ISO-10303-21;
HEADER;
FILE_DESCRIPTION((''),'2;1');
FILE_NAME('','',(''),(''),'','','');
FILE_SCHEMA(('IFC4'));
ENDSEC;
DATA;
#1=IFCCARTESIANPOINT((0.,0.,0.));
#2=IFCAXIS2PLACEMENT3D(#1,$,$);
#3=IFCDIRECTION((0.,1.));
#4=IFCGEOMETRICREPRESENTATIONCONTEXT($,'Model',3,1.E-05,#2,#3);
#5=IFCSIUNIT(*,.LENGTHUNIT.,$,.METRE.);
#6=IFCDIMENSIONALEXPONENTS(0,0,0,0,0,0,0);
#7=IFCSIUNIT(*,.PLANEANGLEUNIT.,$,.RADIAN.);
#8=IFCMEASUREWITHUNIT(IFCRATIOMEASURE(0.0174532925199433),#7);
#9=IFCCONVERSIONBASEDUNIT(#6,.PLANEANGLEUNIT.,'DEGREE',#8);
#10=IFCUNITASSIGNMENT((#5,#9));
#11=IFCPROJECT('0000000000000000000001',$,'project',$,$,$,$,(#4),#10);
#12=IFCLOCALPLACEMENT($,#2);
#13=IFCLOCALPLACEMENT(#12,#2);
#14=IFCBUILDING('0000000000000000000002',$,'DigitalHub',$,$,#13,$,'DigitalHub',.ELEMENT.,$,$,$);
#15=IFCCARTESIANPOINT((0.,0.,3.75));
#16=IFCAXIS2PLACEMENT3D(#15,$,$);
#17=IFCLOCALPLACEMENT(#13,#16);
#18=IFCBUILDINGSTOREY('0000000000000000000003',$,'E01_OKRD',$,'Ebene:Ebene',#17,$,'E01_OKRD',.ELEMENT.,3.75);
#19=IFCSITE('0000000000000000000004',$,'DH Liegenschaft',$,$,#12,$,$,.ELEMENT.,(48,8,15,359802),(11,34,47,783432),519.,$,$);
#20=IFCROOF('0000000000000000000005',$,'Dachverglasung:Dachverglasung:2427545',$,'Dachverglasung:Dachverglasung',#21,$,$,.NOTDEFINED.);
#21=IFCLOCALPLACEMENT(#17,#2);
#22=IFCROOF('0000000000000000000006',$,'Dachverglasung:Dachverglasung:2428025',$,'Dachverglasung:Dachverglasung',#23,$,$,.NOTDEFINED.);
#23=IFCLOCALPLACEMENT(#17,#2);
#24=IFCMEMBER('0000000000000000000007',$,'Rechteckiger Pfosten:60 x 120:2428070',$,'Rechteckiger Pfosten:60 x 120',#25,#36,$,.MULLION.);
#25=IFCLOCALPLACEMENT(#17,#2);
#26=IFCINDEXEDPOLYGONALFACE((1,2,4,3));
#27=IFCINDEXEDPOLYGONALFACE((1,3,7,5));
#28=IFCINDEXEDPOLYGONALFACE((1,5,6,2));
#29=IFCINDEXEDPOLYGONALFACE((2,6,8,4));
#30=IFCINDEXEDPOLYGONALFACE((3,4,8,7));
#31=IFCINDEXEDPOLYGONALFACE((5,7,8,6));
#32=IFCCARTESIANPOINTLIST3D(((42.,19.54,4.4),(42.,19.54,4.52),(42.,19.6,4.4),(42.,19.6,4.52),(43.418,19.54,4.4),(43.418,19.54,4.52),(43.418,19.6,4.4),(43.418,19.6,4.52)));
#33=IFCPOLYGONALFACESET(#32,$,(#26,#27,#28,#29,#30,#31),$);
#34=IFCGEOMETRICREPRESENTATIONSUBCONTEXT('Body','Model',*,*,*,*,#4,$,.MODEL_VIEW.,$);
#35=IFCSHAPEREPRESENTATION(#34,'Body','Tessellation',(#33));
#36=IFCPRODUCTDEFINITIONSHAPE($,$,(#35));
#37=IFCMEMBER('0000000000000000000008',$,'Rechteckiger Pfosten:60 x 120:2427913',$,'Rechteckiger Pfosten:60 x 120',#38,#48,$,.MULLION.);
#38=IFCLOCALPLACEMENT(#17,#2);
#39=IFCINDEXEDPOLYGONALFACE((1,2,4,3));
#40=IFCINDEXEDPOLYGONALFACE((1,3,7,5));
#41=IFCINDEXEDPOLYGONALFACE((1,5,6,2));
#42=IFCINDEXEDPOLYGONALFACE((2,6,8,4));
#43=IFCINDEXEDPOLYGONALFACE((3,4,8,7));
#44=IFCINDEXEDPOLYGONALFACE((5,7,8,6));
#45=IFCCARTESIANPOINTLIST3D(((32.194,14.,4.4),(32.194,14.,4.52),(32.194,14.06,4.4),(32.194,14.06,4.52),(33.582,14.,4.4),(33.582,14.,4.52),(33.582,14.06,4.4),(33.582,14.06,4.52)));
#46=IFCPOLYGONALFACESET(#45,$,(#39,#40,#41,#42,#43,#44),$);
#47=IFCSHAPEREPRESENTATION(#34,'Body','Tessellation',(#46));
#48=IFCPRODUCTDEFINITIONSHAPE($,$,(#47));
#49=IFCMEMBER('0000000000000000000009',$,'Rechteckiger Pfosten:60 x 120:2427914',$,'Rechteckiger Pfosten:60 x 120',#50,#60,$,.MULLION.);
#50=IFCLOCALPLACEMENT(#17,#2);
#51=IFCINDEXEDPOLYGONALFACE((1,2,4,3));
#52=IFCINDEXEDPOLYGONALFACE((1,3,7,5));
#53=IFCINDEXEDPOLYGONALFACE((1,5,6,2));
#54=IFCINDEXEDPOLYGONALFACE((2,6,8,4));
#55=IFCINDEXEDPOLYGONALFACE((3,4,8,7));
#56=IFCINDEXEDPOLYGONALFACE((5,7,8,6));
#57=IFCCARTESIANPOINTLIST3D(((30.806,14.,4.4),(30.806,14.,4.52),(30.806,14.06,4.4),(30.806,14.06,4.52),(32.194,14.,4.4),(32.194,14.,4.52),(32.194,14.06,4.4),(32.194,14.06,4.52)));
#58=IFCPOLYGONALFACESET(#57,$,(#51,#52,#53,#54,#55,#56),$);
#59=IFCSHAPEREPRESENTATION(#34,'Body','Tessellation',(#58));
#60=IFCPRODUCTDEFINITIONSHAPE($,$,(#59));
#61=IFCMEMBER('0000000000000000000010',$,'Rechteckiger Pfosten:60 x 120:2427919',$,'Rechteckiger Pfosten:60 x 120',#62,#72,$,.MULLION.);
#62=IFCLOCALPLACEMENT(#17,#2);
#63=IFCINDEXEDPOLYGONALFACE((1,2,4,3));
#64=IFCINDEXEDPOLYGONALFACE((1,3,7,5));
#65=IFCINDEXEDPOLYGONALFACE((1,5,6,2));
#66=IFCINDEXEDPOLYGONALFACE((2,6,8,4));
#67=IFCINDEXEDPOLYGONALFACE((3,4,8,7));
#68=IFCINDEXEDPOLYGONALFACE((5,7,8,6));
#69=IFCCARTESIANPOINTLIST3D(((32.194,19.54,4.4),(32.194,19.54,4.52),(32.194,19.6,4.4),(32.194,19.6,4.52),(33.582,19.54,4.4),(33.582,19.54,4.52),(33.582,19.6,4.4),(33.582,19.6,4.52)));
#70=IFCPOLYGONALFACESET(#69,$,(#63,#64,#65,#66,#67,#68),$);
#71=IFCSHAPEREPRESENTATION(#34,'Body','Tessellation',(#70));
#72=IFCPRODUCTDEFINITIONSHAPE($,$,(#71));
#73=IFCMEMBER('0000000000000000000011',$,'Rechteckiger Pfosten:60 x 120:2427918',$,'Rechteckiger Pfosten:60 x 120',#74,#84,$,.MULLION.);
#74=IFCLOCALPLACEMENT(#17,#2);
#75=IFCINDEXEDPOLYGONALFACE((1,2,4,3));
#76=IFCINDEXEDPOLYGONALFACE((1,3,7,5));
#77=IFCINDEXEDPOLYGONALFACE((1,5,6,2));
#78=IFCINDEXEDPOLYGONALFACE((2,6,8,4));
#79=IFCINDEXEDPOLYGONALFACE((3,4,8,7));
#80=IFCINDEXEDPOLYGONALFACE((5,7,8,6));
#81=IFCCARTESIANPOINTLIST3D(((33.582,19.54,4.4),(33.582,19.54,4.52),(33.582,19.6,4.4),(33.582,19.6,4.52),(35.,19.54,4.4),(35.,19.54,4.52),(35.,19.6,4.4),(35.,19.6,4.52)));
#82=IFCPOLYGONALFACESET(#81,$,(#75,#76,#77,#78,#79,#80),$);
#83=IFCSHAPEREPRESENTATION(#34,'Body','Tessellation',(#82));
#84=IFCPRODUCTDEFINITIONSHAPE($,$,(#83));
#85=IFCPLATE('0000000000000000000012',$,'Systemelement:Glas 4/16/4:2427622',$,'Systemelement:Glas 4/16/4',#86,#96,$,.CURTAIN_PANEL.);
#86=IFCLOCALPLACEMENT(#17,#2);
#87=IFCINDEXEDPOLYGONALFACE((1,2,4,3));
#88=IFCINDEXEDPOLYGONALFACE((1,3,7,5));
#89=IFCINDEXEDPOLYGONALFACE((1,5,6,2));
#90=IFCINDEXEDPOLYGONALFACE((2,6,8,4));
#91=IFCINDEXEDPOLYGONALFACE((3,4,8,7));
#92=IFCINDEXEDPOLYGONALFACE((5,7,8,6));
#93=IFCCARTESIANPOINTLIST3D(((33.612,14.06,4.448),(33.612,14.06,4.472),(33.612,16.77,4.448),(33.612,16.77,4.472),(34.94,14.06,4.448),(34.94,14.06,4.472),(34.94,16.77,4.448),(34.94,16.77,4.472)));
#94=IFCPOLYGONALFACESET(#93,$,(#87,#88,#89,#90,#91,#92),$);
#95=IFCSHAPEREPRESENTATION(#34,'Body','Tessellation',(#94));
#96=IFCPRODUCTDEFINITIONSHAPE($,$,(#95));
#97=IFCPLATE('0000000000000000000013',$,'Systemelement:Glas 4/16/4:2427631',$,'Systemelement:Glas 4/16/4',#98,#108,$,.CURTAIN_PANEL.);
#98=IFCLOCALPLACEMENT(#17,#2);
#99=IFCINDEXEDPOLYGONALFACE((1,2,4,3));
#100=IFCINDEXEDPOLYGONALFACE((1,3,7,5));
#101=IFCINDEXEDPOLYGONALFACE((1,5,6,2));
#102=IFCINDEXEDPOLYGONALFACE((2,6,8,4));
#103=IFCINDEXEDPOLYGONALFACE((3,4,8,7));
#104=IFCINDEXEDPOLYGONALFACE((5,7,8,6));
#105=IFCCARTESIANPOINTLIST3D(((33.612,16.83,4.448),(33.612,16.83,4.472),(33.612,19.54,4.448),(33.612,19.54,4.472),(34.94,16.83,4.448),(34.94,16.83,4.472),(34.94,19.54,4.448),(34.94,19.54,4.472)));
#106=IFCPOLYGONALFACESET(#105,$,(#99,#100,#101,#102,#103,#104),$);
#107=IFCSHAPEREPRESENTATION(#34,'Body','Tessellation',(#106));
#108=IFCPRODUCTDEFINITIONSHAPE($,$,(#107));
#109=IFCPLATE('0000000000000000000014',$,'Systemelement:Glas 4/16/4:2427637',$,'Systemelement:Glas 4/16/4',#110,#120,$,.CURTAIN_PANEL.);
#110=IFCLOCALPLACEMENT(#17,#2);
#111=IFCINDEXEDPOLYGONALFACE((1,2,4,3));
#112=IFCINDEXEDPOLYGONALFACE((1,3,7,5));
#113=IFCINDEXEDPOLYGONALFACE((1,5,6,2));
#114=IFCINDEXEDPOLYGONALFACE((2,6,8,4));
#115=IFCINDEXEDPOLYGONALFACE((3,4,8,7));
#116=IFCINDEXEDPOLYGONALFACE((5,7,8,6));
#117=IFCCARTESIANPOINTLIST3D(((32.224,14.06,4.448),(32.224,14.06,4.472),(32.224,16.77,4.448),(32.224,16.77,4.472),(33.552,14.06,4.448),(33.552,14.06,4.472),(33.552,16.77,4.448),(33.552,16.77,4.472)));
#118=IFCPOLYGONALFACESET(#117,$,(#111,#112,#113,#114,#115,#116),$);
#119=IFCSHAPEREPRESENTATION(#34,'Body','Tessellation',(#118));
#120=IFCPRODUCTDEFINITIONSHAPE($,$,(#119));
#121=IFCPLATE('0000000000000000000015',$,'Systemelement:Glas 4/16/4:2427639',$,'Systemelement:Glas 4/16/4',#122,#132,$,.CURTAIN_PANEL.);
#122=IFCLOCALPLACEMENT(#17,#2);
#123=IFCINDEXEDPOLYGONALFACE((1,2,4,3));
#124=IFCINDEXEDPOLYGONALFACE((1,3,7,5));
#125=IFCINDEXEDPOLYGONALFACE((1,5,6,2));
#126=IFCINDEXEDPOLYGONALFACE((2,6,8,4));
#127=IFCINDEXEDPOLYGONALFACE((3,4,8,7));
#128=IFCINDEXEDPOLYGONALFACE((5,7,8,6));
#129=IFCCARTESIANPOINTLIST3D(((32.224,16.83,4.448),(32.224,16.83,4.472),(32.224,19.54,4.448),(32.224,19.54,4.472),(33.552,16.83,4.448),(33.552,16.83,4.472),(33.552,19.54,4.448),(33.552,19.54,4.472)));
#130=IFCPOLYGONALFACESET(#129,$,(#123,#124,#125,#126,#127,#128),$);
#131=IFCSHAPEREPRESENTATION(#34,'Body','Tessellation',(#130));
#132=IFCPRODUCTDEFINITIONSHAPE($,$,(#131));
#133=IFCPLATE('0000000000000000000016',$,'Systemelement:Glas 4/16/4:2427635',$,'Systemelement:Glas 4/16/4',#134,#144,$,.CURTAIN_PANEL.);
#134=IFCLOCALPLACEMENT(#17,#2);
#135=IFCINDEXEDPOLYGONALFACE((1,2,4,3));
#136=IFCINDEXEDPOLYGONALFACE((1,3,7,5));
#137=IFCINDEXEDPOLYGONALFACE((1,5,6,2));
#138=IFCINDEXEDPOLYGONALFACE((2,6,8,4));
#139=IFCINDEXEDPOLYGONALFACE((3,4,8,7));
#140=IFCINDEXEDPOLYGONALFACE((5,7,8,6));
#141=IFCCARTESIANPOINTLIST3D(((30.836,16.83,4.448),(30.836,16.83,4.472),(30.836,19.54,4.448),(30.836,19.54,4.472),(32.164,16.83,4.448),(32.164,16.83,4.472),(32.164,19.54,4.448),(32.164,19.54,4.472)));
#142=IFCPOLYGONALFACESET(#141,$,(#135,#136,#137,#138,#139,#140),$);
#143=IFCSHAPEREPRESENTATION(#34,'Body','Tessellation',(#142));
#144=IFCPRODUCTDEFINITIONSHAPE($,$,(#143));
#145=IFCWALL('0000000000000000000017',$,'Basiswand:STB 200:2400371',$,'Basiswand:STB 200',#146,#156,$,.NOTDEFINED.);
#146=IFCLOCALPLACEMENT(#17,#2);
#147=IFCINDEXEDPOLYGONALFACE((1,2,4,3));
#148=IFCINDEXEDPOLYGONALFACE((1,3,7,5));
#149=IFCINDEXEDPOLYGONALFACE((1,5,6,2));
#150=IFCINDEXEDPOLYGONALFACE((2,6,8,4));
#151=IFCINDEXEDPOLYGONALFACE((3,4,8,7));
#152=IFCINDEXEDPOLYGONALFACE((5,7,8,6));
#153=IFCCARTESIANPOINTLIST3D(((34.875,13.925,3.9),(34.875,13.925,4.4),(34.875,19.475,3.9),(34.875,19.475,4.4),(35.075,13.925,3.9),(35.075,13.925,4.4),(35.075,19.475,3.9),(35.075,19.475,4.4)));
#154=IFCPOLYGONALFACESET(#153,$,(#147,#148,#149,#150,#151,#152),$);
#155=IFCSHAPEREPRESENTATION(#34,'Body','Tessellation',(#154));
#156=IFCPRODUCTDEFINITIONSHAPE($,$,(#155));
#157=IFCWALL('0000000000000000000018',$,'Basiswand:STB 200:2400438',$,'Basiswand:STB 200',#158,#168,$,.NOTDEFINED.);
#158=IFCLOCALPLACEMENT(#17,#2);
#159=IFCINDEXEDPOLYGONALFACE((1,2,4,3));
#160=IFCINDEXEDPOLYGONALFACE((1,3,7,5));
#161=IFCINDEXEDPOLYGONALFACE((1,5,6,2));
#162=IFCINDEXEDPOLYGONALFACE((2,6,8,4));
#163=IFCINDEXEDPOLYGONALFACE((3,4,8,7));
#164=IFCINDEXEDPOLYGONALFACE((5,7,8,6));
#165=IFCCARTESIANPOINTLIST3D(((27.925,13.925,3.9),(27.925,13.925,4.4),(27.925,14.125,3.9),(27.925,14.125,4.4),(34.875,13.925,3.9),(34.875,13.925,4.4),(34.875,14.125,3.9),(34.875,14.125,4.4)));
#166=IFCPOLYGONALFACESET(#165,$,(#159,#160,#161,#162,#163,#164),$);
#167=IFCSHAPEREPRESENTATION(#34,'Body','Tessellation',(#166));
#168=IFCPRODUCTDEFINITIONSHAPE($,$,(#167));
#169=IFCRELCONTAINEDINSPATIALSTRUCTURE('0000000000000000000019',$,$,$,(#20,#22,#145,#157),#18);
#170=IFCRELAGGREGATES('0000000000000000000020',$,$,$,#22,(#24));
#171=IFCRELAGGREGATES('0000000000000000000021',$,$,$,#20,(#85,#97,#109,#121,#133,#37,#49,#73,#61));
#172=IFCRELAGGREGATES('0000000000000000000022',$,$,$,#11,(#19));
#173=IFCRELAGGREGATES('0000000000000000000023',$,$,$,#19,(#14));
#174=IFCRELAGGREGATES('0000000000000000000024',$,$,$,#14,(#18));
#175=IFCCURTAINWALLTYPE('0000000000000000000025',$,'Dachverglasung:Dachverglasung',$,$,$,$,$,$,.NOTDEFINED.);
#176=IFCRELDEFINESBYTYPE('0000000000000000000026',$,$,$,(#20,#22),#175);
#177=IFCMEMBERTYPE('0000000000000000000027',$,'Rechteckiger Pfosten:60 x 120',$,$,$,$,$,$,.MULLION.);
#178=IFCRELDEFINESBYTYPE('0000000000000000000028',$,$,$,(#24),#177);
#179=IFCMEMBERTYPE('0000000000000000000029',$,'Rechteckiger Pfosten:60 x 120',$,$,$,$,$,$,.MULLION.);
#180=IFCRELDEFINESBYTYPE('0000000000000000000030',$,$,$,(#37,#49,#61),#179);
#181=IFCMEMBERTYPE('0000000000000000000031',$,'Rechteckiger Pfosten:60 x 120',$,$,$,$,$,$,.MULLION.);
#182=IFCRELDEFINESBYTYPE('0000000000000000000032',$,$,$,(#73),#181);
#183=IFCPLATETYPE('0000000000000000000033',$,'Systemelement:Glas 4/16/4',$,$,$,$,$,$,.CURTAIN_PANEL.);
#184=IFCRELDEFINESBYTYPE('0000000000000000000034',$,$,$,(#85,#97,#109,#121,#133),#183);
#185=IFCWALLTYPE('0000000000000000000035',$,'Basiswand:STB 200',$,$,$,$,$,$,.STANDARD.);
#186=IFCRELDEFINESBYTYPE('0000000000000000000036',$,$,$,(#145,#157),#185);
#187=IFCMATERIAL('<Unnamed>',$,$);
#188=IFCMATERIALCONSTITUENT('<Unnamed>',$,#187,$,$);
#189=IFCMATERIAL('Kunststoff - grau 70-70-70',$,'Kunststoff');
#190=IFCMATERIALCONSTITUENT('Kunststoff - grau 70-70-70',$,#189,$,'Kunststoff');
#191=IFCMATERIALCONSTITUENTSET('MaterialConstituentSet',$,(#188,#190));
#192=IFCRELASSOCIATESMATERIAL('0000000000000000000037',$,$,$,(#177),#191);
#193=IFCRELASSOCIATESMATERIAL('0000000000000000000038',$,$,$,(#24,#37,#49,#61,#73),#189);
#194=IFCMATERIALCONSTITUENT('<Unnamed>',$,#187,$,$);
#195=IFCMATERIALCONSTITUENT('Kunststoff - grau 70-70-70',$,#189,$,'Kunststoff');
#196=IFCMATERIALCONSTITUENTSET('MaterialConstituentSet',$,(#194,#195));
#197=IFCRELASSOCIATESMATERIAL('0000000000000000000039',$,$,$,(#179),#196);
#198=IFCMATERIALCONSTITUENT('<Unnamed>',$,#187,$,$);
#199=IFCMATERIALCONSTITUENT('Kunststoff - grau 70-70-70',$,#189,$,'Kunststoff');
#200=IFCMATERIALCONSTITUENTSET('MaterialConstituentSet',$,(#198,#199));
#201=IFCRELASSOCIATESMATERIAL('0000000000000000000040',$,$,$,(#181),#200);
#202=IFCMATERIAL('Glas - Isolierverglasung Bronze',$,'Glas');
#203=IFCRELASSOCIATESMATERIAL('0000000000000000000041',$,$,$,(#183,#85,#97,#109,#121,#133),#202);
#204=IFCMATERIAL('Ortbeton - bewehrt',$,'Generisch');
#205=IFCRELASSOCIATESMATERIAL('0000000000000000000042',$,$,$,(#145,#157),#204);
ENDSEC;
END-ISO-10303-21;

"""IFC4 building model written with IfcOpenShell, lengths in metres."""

from ifc_helpers import new_model, entity, si_unit, converted_unit, direction, frame, origin, place, context, subcontext, project, spatial, indexed_curve, outline, extrude, source, transform, mapped, material, constituent, constituent_set, type_object, type_shapes, element, aggregate, save


model = new_model("IFC4")

# Units and contexts
model_context = context("Model", 3, precision=1e-05, world=origin(), true_north=direction((0.0, 1.0)))
body_context = subcontext(model_context, "Body", "Model", "MODEL_VIEW")
ifc_project = project(units=[si_unit("LENGTHUNIT", "METRE"), converted_unit("PLANEANGLEUNIT", "DEGREE", entity("IfcRatioMeasure", 0.0174532925199433), si_unit("PLANEANGLEUNIT", "RADIAN"), dimensions=[0, 0, 0, 0, 0, 0, 0])], contexts=[model_context])

# Site, building, storey
site_placement = place(None, frame((0.0, 0.0, 0.0)))
site = spatial("IfcSite", under=ifc_project, at=site_placement, Name="DH Liegenschaft", CompositionType="ELEMENT", RefLatitude=(48, 8, 15, 359802), RefLongitude=(11, 34, 47, 783432), RefElevation=519.0)
building_placement = place(site_placement, origin())
building = spatial("IfcBuilding", under=site, at=building_placement, Name="DigitalHub", LongName="DigitalHub", CompositionType="ELEMENT")
storey_placement = place(building_placement, frame((0.0, 0.0, 3.75)))
storey = spatial("IfcBuildingStorey", under=building, at=storey_placement, Name="E01_OKRD", ObjectType="Ebene:Ebene", LongName="E01_OKRD", CompositionType="ELEMENT", Elevation=3.75)

# Roof
curtain_wall_type = type_object("IfcCurtainWallType", Name="Dachverglasung:Dachverglasung", PredefinedType="NOTDEFINED")
roof_1_placement = place(storey_placement, frame((0.0, 0.0, -3.75)))
roof_1 = element("IfcRoof", 1, at=roof_1_placement, inside=storey, type_object=curtain_wall_type, Name="Dachverglasung:Dachverglasung:2427545", ObjectType="Dachverglasung:Dachverglasung", PredefinedType="NOTDEFINED")
ifc_material_1 = material(Name="Kunststoff - grau 70-70-70", Category="Kunststoff")
ifc_material_2 = material(Name="<Unnamed>")

# Roof
roof_2_placement = place(storey_placement, frame((0.0, 0.0, -3.75)))
roof_2 = element("IfcRoof", 2, at=roof_2_placement, inside=storey, type_object=curtain_wall_type, Name="Dachverglasung:Dachverglasung:2428025", ObjectType="Dachverglasung:Dachverglasung", PredefinedType="NOTDEFINED")

# Members
ifc_constituent_1 = constituent(ifc_material_2, Name="<Unnamed>")
ifc_constituent_2 = constituent(ifc_material_1, Name="Kunststoff - grau 70-70-70", Category="Kunststoff")
ifc_constituent_set_1 = constituent_set(constituents=[ifc_constituent_1, ifc_constituent_2], Name="MaterialConstituentSet")
member_type_1 = type_object("IfcMemberType", Name="Rechteckiger Pfosten:60 x 120", PredefinedType="MULLION", material=ifc_constituent_set_1)
shared_shape_1 = source(origin(), body_context, "Body", "SweptSolid", [
    extrude(outline(indexed_curve([(-0.06, -0.03), (0.06, -0.03), (0.06, 0.03), (-0.06, 0.03), (-0.06, -0.03)], self_intersect=False)), frame((-0.03, 0.0, -1.418), z_axis=(0.0, 0.0, 1.0), x_axis=(0.0, -1.0, 0.0)), (0.0, 0.0, 1.0), 1.418),
])
type_shapes(member_type_1, [shared_shape_1])
member_1_placement = place(storey_placement, frame((42.0, 19.6, 4.46), z_axis=(-1.0, 0.0, 0.0), x_axis=(0.0, 1.0, 0.0)))
member_1 = element("IfcMember", 3, at=member_1_placement, type_object=member_type_1, material=ifc_material_1, Name="Rechteckiger Pfosten:60 x 120:2428070", ObjectType="Rechteckiger Pfosten:60 x 120", PredefinedType="MULLION", context=body_context, shape_type="MappedRepresentation", body=[
    mapped(shared_shape_1, transform((0.0, 0.0, 0.0), scale=1.0)),
])
aggregate(roof_2, [member_1])
ifc_constituent_3 = constituent(ifc_material_2, Name="<Unnamed>")
ifc_constituent_4 = constituent(ifc_material_1, Name="Kunststoff - grau 70-70-70", Category="Kunststoff")
ifc_constituent_set_2 = constituent_set(constituents=[ifc_constituent_3, ifc_constituent_4], Name="MaterialConstituentSet")
member_type_2 = type_object("IfcMemberType", Name="Rechteckiger Pfosten:60 x 120", PredefinedType="MULLION", material=ifc_constituent_set_2)
shared_shape_2 = source(origin(), body_context, "Body", "SweptSolid", [
    extrude(outline(indexed_curve([(-0.06, -0.03), (0.06, -0.03), (0.06, 0.03), (-0.06, 0.03), (-0.06, -0.03)], self_intersect=False)), frame((-0.03, 0.0, -1.388), z_axis=(0.0, 0.0, 1.0), x_axis=(0.0, -1.0, 0.0)), (0.0, 0.0, 1.0), 1.388),
])
type_shapes(member_type_2, [shared_shape_2])
member_2_placement = place(storey_placement, frame((33.582, 14.0, 4.46), z_axis=(1.0, 0.0, 0.0), x_axis=(0.0, -1.0, 0.0)))
member_2 = element("IfcMember", 4, at=member_2_placement, type_object=member_type_2, material=ifc_material_1, Name="Rechteckiger Pfosten:60 x 120:2427913", ObjectType="Rechteckiger Pfosten:60 x 120", PredefinedType="MULLION", context=body_context, shape_type="MappedRepresentation", body=[
    mapped(shared_shape_2, transform((0.0, 0.0, 0.0), scale=1.0)),
])
member_3_placement = place(storey_placement, frame((32.194, 14.0, 4.46), z_axis=(1.0, 0.0, 0.0), x_axis=(0.0, -1.0, 0.0)))
member_3 = element("IfcMember", 5, at=member_3_placement, type_object=member_type_2, material=ifc_material_1, Name="Rechteckiger Pfosten:60 x 120:2427914", ObjectType="Rechteckiger Pfosten:60 x 120", PredefinedType="MULLION", context=body_context, shape_type="MappedRepresentation", body=[
    mapped(shared_shape_2, transform((0.0, 0.0, 0.0), scale=1.0)),
])
member_4_placement = place(storey_placement, frame((32.194, 19.6, 4.46), z_axis=(-1.0, 0.0, 0.0), x_axis=(0.0, 1.0, 0.0)))
member_4 = element("IfcMember", 6, at=member_4_placement, type_object=member_type_2, material=ifc_material_1, Name="Rechteckiger Pfosten:60 x 120:2427919", ObjectType="Rechteckiger Pfosten:60 x 120", PredefinedType="MULLION", context=body_context, shape_type="MappedRepresentation", body=[
    mapped(shared_shape_2, transform((0.0, 0.0, 0.0), scale=1.0)),
])
ifc_constituent_5 = constituent(ifc_material_2, Name="<Unnamed>")
ifc_constituent_6 = constituent(ifc_material_1, Name="Kunststoff - grau 70-70-70", Category="Kunststoff")
ifc_constituent_set_3 = constituent_set(constituents=[ifc_constituent_5, ifc_constituent_6], Name="MaterialConstituentSet")
member_type_3 = type_object("IfcMemberType", Name="Rechteckiger Pfosten:60 x 120", PredefinedType="MULLION", material=ifc_constituent_set_3)
shared_shape_3 = source(origin(), body_context, "Body", "SweptSolid", [
    extrude(outline(indexed_curve([(-0.06, -0.03), (0.06, -0.03), (0.06, 0.03), (-0.06, 0.03), (-0.06, -0.03)], self_intersect=False)), frame((-0.03, 0.0, -1.418), z_axis=(0.0, 0.0, 1.0), x_axis=(0.0, -1.0, 0.0)), (0.0, 0.0, 1.0), 1.418),
])
type_shapes(member_type_3, [shared_shape_3])
member_5_placement = place(storey_placement, frame((33.582, 19.6, 4.46), z_axis=(-1.0, 0.0, 0.0), x_axis=(0.0, 1.0, 0.0)))
member_5 = element("IfcMember", 7, at=member_5_placement, type_object=member_type_3, material=ifc_material_1, Name="Rechteckiger Pfosten:60 x 120:2427918", ObjectType="Rechteckiger Pfosten:60 x 120", PredefinedType="MULLION", context=body_context, shape_type="MappedRepresentation", body=[
    mapped(shared_shape_3, transform((0.0, 0.0, 0.0), scale=1.0)),
])

# Plates
ifc_material_3 = material(Name="Glas - Isolierverglasung Bronze", Category="Glas")
plate_type = type_object("IfcPlateType", Name="Systemelement:Glas 4/16/4", PredefinedType="CURTAIN_PANEL", material=ifc_material_3)
shared_shape_4 = source(origin(), body_context, "Body", "SweptSolid", [
    extrude(outline(indexed_curve([(-0.012, -1.355), (0.012, -1.355), (0.012, 1.355), (-0.012, 1.355), (-0.012, -1.355)], self_intersect=False)), frame((0.0, 0.0, 0.0), z_axis=(0.0, 0.0, 1.0), x_axis=(0.0, 1.0, 0.0)), (0.0, 0.0, 1.0), 1.328),
])
type_shapes(plate_type, [shared_shape_4])
plate_1_placement = place(roof_1_placement, frame((34.94, 15.415, 8.21), z_axis=(-1.0, 0.0, 0.0), x_axis=(0.0, 1.0, 0.0)))
plate_1 = element("IfcPlate", 8, at=plate_1_placement, type_object=plate_type, material=ifc_material_3, Name="Systemelement:Glas 4/16/4:2427622", ObjectType="Systemelement:Glas 4/16/4", PredefinedType="CURTAIN_PANEL", context=body_context, shape_type="MappedRepresentation", body=[
    mapped(shared_shape_4, transform((0.0, 0.0, 0.0), scale=1.0)),
])
plate_2_placement = place(roof_1_placement, frame((34.94, 18.185, 8.21), z_axis=(-1.0, 0.0, 0.0), x_axis=(0.0, 1.0, 0.0)))
plate_2 = element("IfcPlate", 9, at=plate_2_placement, type_object=plate_type, material=ifc_material_3, Name="Systemelement:Glas 4/16/4:2427631", ObjectType="Systemelement:Glas 4/16/4", PredefinedType="CURTAIN_PANEL", context=body_context, shape_type="MappedRepresentation", body=[
    mapped(shared_shape_4, transform((0.0, 0.0, 0.0), scale=1.0)),
])
plate_3_placement = place(roof_1_placement, frame((33.552, 15.415, 8.21), z_axis=(-1.0, 0.0, 0.0), x_axis=(0.0, 1.0, 0.0)))
plate_3 = element("IfcPlate", 10, at=plate_3_placement, type_object=plate_type, material=ifc_material_3, Name="Systemelement:Glas 4/16/4:2427637", ObjectType="Systemelement:Glas 4/16/4", PredefinedType="CURTAIN_PANEL", context=body_context, shape_type="MappedRepresentation", body=[
    mapped(shared_shape_4, transform((0.0, 0.0, 0.0), scale=1.0)),
])
plate_4_placement = place(roof_1_placement, frame((33.552, 18.185, 8.21), z_axis=(-1.0, 0.0, 0.0), x_axis=(0.0, 1.0, 0.0)))
plate_4 = element("IfcPlate", 11, at=plate_4_placement, type_object=plate_type, material=ifc_material_3, Name="Systemelement:Glas 4/16/4:2427639", ObjectType="Systemelement:Glas 4/16/4", PredefinedType="CURTAIN_PANEL", context=body_context, shape_type="MappedRepresentation", body=[
    mapped(shared_shape_4, transform((0.0, 0.0, 0.0), scale=1.0)),
])
plate_5_placement = place(roof_1_placement, frame((32.164, 18.185, 8.21), z_axis=(-1.0, 0.0, 0.0), x_axis=(0.0, 1.0, 0.0)))
plate_5 = element("IfcPlate", 12, at=plate_5_placement, type_object=plate_type, material=ifc_material_3, Name="Systemelement:Glas 4/16/4:2427635", ObjectType="Systemelement:Glas 4/16/4", PredefinedType="CURTAIN_PANEL", context=body_context, shape_type="MappedRepresentation", body=[
    mapped(shared_shape_4, transform((0.0, 0.0, 0.0), scale=1.0)),
])
aggregate(roof_1, [plate_1, plate_2, plate_3, plate_4, plate_5, member_2, member_3, member_5, member_4])

# Walls
ifc_material_4 = material(Name="Ortbeton - bewehrt", Category="Generisch")
wall_type = type_object("IfcWallType", Name="Basiswand:STB 200", PredefinedType="STANDARD")
wall_1_placement = place(storey_placement, frame((34.975, 19.475, 3.9), z_axis=(0.0, 0.0, 1.0), x_axis=(0.0, -1.0, 0.0)))
element("IfcWall", 13, at=wall_1_placement, inside=storey, type_object=wall_type, material=ifc_material_4, Name="Basiswand:STB 200:2400371", ObjectType="Basiswand:STB 200", PredefinedType="NOTDEFINED", context=body_context, shape_type="SweptSolid", body=[
    extrude(outline(indexed_curve([(5.55, 0.1), (0.0, 0.1), (0.0, -0.1), (5.55, -0.1), (5.55, 0.1)], self_intersect=False)), origin(), (0.0, 0.0, 1.0), 0.5),
])
wall_2_placement = place(storey_placement, frame((34.875, 14.025, 3.9), z_axis=(0.0, 0.0, 1.0), x_axis=(-1.0, 0.0, 0.0)))
element("IfcWall", 14, at=wall_2_placement, inside=storey, type_object=wall_type, material=ifc_material_4, Name="Basiswand:STB 200:2400438", ObjectType="Basiswand:STB 200", PredefinedType="NOTDEFINED", context=body_context, shape_type="SweptSolid", body=[
    extrude(outline(indexed_curve([(6.95, 0.1), (0.0, 0.1), (0.0, -0.1), (6.95, -0.1), (6.95, 0.1)], self_intersect=False)), origin(), (0.0, 0.0, 1.0), 0.5),
])

save(model, "model.ifc")
